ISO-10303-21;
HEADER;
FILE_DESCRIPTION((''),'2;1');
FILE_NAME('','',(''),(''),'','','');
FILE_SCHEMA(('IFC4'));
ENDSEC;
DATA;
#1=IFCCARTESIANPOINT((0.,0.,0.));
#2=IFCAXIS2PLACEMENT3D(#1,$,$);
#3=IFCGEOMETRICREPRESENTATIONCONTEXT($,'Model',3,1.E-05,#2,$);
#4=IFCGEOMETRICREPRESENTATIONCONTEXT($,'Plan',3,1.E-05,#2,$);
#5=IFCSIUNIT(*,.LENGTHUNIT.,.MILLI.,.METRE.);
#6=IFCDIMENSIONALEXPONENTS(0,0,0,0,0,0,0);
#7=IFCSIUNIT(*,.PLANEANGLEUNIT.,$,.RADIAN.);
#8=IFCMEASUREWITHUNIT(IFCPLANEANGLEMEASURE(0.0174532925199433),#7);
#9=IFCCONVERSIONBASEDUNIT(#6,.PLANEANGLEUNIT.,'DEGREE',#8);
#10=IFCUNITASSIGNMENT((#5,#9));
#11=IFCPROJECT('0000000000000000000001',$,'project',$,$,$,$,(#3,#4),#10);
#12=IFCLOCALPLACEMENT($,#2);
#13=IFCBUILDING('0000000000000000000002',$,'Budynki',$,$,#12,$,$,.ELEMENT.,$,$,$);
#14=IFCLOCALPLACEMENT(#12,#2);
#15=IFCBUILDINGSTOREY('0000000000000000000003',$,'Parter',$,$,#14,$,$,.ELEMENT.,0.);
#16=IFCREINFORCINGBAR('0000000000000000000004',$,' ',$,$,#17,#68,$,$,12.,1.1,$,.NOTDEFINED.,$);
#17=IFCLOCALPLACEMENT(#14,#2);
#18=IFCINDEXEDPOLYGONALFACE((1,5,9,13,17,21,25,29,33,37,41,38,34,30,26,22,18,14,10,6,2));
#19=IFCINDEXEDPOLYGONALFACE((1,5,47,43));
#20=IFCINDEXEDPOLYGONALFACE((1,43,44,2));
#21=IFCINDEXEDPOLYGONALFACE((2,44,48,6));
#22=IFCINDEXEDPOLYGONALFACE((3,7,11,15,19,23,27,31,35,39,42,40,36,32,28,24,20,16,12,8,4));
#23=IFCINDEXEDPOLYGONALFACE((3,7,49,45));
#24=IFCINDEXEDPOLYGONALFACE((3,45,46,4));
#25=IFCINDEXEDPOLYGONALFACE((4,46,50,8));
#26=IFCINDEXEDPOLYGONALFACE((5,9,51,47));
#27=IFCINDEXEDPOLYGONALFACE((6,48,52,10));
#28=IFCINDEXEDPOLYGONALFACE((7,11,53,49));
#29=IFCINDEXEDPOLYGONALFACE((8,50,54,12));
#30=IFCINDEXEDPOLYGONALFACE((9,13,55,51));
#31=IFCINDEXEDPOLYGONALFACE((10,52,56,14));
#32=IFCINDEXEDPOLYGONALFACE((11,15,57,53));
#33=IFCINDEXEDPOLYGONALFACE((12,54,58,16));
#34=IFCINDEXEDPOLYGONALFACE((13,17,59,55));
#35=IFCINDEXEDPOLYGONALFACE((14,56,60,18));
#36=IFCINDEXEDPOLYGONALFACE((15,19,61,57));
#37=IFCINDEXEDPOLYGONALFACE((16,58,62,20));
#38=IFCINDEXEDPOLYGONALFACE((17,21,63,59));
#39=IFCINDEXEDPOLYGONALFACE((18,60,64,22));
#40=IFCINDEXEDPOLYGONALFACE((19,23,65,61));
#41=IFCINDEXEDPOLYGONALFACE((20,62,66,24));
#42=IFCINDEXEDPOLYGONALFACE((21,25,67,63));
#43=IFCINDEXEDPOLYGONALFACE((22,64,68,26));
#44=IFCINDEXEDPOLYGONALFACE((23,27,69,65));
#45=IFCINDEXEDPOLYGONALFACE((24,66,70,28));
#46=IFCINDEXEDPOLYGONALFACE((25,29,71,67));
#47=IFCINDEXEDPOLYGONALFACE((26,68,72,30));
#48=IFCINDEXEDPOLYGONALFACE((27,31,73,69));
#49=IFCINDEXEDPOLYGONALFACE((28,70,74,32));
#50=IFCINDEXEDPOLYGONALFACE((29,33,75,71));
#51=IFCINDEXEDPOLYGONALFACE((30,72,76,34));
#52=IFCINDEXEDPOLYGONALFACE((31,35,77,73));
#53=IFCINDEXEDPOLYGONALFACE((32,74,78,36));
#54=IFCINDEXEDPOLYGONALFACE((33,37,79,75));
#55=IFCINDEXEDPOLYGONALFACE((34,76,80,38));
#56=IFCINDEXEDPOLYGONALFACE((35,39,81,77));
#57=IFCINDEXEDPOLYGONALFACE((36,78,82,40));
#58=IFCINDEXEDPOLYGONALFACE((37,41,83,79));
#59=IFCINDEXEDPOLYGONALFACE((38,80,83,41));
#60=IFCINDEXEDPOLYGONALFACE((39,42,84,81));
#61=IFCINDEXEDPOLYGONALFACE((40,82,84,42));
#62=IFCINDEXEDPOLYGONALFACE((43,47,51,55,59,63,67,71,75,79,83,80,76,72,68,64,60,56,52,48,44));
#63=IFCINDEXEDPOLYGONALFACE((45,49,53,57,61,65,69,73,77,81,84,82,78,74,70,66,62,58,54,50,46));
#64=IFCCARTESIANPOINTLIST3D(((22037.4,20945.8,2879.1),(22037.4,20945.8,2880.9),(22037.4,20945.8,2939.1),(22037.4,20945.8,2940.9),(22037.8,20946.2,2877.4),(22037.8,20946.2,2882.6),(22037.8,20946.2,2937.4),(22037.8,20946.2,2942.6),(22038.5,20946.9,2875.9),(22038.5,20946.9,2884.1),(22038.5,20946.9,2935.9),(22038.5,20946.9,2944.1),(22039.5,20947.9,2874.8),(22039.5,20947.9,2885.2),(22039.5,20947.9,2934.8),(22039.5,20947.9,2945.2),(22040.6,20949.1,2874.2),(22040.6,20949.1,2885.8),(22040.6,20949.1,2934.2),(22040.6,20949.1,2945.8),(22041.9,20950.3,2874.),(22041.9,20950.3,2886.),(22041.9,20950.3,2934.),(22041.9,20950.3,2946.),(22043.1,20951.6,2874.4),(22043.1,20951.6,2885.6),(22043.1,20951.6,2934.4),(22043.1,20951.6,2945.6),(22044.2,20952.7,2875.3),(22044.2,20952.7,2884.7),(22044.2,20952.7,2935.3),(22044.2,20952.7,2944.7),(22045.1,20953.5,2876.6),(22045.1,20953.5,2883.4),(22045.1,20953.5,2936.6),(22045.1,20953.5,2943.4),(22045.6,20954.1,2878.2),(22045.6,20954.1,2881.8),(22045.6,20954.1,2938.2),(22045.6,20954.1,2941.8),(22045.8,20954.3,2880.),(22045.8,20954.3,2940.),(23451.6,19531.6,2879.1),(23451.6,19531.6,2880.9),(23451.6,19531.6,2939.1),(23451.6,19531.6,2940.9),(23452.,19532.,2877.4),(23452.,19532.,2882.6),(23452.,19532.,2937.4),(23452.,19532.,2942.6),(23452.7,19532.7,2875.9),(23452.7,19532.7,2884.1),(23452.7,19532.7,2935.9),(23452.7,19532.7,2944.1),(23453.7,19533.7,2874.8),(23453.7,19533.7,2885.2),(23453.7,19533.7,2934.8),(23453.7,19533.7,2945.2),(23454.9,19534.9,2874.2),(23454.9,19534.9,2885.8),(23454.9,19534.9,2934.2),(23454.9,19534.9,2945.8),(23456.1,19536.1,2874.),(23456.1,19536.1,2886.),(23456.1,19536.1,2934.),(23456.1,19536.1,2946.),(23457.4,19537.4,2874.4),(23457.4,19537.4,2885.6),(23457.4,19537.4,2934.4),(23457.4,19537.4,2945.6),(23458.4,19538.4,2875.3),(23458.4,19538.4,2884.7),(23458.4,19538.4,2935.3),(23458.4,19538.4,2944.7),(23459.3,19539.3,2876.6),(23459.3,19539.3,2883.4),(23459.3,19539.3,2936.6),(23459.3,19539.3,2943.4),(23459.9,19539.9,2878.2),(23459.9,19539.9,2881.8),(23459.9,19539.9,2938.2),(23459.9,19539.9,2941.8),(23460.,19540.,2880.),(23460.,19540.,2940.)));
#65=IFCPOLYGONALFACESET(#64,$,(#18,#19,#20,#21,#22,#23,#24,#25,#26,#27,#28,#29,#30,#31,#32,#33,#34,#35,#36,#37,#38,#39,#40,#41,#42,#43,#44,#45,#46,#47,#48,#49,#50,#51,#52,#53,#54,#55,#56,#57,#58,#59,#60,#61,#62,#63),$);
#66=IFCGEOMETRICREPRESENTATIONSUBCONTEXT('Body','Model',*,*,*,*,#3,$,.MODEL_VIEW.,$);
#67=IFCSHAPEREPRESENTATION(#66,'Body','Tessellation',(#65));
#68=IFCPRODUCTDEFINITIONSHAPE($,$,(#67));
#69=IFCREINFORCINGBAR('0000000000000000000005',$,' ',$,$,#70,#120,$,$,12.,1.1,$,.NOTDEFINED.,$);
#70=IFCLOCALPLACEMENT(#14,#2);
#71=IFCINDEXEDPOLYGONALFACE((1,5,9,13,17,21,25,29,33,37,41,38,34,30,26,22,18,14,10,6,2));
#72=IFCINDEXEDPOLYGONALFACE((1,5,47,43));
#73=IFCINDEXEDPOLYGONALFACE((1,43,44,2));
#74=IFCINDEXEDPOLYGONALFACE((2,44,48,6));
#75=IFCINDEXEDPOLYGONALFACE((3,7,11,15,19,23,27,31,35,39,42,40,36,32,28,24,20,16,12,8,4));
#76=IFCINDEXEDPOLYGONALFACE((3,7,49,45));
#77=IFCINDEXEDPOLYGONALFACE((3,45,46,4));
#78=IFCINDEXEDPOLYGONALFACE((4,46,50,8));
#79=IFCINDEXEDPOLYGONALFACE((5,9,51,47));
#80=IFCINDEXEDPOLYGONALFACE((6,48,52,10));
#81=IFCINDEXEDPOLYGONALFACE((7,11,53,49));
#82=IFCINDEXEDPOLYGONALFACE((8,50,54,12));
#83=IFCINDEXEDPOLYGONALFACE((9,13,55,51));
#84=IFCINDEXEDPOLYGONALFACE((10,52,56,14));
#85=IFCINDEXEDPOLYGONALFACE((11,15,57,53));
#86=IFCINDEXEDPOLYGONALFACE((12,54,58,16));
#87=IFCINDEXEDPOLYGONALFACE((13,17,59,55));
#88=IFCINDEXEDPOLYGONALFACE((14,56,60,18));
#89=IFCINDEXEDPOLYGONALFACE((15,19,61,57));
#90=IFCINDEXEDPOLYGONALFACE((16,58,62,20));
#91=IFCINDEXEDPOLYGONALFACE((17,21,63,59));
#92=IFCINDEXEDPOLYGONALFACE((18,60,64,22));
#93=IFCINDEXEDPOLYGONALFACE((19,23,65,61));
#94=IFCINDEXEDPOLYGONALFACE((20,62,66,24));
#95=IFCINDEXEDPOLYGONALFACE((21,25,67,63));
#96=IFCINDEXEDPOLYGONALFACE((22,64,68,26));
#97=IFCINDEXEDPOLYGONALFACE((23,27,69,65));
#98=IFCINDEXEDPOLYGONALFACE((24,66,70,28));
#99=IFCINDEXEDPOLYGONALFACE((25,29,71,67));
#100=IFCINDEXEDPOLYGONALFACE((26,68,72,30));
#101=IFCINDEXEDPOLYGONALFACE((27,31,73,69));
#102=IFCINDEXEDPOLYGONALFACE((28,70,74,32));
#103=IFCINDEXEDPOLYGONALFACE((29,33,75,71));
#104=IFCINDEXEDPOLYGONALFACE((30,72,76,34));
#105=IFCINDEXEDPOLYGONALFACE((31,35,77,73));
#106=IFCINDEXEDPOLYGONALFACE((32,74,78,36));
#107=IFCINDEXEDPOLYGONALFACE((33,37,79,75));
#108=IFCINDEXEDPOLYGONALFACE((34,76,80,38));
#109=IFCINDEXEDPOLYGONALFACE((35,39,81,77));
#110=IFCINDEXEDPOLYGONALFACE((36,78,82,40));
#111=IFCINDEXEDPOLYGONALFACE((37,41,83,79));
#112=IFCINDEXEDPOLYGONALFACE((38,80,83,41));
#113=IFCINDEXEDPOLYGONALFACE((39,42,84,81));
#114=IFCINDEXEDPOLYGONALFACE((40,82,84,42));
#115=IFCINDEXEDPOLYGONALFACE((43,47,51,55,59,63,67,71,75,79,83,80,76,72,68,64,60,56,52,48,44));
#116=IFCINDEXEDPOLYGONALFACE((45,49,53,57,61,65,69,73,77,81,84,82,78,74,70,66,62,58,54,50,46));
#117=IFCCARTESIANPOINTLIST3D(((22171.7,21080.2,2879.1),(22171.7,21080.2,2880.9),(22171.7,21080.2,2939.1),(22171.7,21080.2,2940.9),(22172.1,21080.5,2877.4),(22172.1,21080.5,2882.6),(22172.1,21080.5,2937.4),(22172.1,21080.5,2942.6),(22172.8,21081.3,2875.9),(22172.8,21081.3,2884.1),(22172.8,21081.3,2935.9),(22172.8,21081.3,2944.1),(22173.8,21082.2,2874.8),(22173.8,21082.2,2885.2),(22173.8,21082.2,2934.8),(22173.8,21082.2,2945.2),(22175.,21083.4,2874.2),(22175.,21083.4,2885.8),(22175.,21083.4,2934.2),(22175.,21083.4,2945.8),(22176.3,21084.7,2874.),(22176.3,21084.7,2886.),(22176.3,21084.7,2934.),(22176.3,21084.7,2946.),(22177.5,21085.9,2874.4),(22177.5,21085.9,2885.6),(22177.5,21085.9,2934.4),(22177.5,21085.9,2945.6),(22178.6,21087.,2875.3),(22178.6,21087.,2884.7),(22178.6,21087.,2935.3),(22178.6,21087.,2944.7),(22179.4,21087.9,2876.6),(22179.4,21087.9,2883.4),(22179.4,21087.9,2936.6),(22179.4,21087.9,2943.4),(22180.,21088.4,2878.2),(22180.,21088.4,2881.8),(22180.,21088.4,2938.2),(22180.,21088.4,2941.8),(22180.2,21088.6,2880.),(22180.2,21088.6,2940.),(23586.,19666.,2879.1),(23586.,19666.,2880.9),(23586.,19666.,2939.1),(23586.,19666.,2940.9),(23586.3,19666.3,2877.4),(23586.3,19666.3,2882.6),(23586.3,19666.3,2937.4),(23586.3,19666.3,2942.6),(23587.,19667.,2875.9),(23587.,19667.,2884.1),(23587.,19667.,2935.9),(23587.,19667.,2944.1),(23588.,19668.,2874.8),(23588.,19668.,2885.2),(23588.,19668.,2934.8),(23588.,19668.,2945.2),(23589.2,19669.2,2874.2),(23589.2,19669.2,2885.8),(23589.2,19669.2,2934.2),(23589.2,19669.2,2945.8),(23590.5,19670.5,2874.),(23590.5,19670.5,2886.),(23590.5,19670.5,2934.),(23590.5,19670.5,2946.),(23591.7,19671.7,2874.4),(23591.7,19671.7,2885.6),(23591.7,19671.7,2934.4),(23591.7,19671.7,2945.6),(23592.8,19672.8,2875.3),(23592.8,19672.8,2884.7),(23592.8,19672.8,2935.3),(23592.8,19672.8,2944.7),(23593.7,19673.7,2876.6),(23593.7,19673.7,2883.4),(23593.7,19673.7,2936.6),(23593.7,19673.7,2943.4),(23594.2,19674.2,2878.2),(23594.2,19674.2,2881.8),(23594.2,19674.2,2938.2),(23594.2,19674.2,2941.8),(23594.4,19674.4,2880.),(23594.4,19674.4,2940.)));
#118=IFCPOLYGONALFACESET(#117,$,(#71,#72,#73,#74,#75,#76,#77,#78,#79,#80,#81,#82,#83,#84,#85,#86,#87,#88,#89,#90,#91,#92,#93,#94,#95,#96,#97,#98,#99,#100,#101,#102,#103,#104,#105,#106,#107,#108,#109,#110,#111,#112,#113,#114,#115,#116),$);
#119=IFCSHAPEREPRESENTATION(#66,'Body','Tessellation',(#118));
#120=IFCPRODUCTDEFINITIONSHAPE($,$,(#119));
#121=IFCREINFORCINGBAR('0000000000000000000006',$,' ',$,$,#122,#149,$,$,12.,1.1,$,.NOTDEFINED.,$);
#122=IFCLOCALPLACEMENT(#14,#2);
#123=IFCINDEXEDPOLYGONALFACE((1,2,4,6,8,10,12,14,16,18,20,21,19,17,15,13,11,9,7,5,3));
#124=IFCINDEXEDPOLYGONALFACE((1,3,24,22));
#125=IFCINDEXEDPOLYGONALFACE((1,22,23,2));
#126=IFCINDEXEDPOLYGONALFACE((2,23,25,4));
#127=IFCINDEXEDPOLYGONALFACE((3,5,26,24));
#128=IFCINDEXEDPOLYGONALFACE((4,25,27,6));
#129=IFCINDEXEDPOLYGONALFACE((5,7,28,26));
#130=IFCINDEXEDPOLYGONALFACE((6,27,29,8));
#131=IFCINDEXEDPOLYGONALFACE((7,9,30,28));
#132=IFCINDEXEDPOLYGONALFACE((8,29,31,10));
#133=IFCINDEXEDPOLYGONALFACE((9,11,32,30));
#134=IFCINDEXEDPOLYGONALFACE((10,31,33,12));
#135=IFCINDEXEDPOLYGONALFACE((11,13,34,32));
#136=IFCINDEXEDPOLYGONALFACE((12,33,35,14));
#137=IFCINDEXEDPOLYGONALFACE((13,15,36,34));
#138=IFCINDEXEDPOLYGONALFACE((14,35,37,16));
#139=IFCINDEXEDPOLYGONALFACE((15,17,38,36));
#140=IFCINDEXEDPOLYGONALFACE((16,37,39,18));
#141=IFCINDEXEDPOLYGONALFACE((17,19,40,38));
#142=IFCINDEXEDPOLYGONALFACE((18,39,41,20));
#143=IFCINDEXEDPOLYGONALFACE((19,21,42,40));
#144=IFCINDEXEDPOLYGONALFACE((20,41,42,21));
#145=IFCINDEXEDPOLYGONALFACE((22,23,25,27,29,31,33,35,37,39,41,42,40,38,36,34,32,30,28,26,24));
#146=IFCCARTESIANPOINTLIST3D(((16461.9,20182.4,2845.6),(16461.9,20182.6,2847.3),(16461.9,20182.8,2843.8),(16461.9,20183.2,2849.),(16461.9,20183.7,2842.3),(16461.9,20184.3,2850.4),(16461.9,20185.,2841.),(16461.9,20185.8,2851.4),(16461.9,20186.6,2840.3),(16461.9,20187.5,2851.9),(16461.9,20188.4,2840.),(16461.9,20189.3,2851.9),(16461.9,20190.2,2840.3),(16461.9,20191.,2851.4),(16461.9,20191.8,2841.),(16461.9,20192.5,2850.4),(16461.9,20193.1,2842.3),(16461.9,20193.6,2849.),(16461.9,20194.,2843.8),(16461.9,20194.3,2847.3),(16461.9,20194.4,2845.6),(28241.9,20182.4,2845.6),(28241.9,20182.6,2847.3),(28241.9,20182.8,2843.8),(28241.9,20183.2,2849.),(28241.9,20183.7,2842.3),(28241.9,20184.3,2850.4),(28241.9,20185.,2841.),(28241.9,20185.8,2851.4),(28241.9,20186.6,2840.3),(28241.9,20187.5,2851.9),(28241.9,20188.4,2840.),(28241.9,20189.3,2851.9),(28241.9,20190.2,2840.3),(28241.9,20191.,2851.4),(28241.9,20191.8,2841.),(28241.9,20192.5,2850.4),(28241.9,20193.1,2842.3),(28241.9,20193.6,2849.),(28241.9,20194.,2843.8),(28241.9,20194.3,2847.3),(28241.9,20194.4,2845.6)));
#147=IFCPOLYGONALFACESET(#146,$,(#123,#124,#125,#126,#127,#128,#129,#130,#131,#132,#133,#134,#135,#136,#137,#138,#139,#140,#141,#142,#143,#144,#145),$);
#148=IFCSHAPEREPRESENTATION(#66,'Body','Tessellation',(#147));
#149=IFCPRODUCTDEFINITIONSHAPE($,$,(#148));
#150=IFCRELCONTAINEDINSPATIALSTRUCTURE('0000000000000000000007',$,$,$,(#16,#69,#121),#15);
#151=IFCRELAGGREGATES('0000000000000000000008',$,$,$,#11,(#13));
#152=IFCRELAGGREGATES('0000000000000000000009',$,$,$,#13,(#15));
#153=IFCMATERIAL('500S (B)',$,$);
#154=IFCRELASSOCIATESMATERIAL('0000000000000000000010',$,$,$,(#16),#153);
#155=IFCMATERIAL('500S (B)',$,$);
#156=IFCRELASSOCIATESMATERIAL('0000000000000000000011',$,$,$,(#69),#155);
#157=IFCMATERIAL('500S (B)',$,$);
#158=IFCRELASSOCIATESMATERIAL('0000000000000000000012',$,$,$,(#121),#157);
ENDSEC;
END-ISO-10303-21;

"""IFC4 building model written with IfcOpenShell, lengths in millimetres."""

from ifc_helpers import new_model, entity, si_unit, converted_unit, frame, origin, origin_with_axes, place, context, subcontext, project, spatial, source, transform, mapped, material, element, save


model = new_model("IFC4")

# Units and contexts
model_context = context("Model", 3, precision=1e-05, world=origin())
plan_context = context("Plan", 3, precision=1e-05, world=origin())
body_context = subcontext(model_context, "Body", "Model", "MODEL_VIEW")
ifc_project = project(units=[si_unit("LENGTHUNIT", "METRE", prefix="MILLI"), converted_unit("PLANEANGLEUNIT", "DEGREE", entity("IfcPlaneAngleMeasure", 0.0174532925199433), si_unit("PLANEANGLEUNIT", "RADIAN"), dimensions=[0, 0, 0, 0, 0, 0, 0])], contexts=[model_context, plan_context])

# Building, storey
building_placement = place(None, origin())
building = spatial("IfcBuilding", under=ifc_project, at=building_placement, Name="Budynki", CompositionType="ELEMENT")
storey_placement = place(building_placement, origin())
storey = spatial("IfcBuildingStorey", under=building, at=storey_placement, Name="Parter", CompositionType="ELEMENT", Elevation=0.0)

# Reinforcing bars
ifc_material_1 = material(Name="500S (B)")
shared_shape_1 = source(origin_with_axes(), body_context, "Body", "AdvancedSweptSolid", [
    entity("IfcSweptDiskSolid", entity("IfcPolyline", [entity("IfcCartesianPoint", [0.0, 0.0, 0.0]), entity("IfcCartesianPoint", [1414.2, -1414.2, 0.0])]), 6.0, None, 0.0, 1.0),
])
reinforcing_bar_1_placement = place(storey_placement, frame((22041.6, 20950.0, 2880.0)))
element("IfcReinforcingBar", 1, at=reinforcing_bar_1_placement, inside=storey, material=ifc_material_1, Name=" ", CrossSectionArea=1.1, NominalDiameter=12.0, PredefinedType="NOTDEFINED", context=body_context, shape_type="MappedRepresentation", body=[
    mapped(shared_shape_1, transform((0.0, 0.0, 0.0), y_axis=(0.0, 1.0, 0.0), scale=1.0)),
    mapped(shared_shape_1, transform((0.0, 0.0, 60.0), y_axis=(0.0, 1.0, 0.0), scale=1.0)),
])
ifc_material_2 = material(Name="500S (B)")
shared_shape_2 = source(origin_with_axes(), body_context, "Body", "AdvancedSweptSolid", [
    entity("IfcSweptDiskSolid", entity("IfcPolyline", [entity("IfcCartesianPoint", [0.0, 0.0, 0.0]), entity("IfcCartesianPoint", [1414.2, -1414.2, 0.0])]), 6.0, None, 0.0, 1.0),
])
reinforcing_bar_2_placement = place(storey_placement, frame((22175.9, 21084.4, 2880.0)))
element("IfcReinforcingBar", 2, at=reinforcing_bar_2_placement, inside=storey, material=ifc_material_2, Name=" ", CrossSectionArea=1.1, NominalDiameter=12.0, PredefinedType="NOTDEFINED", context=body_context, shape_type="MappedRepresentation", body=[
    mapped(shared_shape_2, transform((0.0, 0.0, 0.0), y_axis=(0.0, 1.0, 0.0), scale=1.0)),
    mapped(shared_shape_2, transform((0.0, 0.0, 60.0), y_axis=(0.0, 1.0, 0.0), scale=1.0)),
])
ifc_material_3 = material(Name="500S (B)")
reinforcing_bar_3_placement = place(storey_placement, frame((28241.9, 20188.4, 2846.0)))
element("IfcReinforcingBar", 3, at=reinforcing_bar_3_placement, inside=storey, material=ifc_material_3, Name=" ", CrossSectionArea=1.1, NominalDiameter=12.0, PredefinedType="NOTDEFINED", context=body_context, shape_type="AdvancedSweptSolid", body=[
    entity("IfcSweptDiskSolid", entity("IfcPolyline", [entity("IfcCartesianPoint", [0.0, 0.0, 0.0]), entity("IfcCartesianPoint", [-11780.0, 0.0, 0.0])]), 6.0, None, 0.0, 1.0),
])

save(model, "model.ifc")
